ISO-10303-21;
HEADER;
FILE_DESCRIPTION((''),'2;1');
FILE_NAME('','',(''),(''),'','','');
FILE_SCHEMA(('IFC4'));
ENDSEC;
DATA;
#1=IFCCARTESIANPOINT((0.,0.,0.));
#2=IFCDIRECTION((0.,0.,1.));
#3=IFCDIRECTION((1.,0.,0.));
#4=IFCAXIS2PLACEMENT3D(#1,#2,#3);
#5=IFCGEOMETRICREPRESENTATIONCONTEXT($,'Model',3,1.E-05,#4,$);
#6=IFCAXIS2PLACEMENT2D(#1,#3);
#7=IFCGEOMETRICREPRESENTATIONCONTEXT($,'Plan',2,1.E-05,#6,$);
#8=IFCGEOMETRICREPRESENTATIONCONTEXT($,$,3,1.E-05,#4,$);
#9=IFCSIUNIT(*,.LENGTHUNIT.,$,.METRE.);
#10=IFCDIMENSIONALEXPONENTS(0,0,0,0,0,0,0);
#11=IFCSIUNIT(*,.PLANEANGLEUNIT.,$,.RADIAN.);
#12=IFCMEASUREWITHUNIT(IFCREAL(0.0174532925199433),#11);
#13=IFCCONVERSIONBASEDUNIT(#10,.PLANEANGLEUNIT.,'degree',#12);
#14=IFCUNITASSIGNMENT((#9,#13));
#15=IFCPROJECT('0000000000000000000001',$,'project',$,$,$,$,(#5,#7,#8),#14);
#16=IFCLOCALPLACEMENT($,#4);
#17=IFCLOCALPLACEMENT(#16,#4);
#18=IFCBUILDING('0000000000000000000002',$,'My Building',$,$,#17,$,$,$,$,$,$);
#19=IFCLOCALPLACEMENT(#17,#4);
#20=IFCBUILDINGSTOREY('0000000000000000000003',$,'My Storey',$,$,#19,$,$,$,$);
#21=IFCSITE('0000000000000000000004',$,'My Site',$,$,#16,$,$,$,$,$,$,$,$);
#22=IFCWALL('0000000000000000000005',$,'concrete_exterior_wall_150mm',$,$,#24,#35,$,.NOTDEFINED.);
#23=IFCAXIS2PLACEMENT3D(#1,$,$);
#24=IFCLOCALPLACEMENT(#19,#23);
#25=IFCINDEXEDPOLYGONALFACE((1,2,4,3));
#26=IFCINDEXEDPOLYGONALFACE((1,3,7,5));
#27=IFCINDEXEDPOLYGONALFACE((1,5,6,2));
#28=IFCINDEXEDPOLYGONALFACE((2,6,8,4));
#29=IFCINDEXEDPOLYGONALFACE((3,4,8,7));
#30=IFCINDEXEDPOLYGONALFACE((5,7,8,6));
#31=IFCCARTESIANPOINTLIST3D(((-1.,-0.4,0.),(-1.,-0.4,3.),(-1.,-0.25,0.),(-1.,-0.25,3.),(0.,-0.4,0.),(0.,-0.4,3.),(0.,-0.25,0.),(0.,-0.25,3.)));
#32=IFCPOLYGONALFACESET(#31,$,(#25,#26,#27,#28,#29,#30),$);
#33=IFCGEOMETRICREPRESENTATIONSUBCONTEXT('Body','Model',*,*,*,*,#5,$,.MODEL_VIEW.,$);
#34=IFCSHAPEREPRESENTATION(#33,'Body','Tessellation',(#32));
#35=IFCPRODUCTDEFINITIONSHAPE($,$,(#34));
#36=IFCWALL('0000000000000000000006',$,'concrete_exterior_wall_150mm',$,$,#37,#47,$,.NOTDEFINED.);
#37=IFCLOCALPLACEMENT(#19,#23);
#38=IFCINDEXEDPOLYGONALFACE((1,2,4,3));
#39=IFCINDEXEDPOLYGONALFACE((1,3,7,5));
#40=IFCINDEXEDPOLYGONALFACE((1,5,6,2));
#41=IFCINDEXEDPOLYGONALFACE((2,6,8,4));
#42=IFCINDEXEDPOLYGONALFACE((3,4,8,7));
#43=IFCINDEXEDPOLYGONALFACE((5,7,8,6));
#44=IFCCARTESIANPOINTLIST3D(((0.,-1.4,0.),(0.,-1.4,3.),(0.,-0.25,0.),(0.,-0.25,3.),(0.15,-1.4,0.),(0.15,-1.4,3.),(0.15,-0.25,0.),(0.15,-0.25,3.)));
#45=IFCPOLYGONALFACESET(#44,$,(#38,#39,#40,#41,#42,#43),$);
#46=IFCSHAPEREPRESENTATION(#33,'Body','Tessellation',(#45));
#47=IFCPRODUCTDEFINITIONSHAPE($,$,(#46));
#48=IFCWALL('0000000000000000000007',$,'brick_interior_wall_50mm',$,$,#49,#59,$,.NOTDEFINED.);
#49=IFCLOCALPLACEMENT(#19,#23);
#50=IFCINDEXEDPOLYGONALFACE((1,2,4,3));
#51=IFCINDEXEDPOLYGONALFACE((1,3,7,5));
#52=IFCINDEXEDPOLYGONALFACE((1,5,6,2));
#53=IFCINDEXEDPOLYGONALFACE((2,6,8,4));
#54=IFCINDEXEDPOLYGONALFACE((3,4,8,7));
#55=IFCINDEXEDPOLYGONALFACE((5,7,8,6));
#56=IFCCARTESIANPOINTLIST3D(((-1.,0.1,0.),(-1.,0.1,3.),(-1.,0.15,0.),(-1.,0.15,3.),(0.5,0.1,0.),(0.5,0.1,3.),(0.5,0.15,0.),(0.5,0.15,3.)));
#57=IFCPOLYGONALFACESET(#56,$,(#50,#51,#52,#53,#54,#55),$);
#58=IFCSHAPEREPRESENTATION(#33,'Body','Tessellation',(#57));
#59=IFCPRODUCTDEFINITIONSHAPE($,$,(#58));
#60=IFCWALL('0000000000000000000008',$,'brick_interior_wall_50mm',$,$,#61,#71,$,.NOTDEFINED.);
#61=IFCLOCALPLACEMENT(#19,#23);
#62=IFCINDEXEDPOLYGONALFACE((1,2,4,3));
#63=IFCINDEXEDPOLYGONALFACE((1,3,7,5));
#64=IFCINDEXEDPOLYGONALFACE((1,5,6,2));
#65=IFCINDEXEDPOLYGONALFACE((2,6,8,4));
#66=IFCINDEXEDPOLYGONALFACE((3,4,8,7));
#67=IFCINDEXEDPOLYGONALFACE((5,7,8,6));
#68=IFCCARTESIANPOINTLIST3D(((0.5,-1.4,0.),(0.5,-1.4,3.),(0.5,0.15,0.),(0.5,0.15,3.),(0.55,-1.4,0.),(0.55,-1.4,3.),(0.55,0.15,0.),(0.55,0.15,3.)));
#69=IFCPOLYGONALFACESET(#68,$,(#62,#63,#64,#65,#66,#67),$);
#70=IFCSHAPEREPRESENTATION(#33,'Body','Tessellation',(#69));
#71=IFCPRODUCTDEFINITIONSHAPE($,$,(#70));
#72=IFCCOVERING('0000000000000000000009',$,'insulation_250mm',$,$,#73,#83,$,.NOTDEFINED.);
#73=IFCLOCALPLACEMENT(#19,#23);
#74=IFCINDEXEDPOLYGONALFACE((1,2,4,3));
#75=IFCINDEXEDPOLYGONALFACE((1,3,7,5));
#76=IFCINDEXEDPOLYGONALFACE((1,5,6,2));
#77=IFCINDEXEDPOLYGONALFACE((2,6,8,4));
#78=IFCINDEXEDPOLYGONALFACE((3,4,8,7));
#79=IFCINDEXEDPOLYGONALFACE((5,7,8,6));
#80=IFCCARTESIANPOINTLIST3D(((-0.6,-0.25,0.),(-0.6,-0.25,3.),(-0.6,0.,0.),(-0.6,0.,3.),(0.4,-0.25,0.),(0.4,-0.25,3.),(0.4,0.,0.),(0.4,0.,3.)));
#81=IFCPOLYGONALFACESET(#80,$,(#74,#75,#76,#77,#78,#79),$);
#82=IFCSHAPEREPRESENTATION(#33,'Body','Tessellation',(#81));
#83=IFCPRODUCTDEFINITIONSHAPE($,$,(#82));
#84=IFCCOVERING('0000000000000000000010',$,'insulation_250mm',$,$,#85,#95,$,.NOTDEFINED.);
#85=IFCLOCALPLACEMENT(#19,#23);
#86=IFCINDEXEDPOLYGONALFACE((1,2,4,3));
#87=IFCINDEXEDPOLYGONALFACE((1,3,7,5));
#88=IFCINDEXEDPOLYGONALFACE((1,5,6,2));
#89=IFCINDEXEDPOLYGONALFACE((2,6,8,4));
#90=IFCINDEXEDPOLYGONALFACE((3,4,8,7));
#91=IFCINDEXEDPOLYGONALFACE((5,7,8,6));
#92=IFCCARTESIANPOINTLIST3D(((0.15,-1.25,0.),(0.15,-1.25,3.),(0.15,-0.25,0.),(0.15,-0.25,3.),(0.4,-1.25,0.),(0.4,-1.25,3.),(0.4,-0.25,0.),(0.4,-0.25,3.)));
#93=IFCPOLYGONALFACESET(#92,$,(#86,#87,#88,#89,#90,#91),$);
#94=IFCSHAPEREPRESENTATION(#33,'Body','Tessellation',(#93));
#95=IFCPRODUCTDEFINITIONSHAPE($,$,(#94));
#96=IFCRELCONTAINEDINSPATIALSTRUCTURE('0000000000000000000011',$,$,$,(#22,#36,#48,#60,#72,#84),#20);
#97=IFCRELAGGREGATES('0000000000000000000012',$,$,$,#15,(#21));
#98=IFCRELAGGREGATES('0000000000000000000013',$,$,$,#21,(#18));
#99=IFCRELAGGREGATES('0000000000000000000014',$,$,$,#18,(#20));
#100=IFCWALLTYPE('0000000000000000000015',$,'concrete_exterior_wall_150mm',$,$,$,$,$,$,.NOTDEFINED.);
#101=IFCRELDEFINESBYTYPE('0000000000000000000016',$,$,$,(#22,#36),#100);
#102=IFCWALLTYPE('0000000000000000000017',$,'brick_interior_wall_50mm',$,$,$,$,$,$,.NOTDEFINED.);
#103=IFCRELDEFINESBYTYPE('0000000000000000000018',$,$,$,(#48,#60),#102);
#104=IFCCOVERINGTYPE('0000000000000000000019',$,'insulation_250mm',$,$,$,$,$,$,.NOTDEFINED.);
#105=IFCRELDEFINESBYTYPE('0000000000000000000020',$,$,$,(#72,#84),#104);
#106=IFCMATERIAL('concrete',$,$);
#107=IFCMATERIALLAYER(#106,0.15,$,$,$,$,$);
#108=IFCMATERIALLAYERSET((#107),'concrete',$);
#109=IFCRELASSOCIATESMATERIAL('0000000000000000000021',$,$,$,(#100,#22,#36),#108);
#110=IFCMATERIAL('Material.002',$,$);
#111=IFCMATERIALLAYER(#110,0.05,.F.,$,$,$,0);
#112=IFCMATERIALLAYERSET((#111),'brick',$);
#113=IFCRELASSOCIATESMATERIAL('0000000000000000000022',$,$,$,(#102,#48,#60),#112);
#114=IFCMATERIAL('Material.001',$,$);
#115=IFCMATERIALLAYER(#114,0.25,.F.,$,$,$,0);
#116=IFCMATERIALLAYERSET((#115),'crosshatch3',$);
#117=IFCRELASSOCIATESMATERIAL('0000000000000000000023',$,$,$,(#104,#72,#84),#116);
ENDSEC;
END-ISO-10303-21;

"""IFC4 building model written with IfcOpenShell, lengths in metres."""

from ifc_helpers import new_model, entity, si_unit, converted_unit, frame, frame_2d, origin_with_axes, place, context, subcontext, project, spatial, indexed_curve, outline, extrude, material, layer, layer_set, layer_usage, type_object, element, save


model = new_model("IFC4")

# Units and contexts
model_context = context("Model", 3, precision=1e-05, world=origin_with_axes())
plan_context = context("Plan", 2, precision=1e-05, world=frame_2d((0.0, 0.0, 0.0), x_axis=(1.0, 0.0, 0.0)))
context_of_model = context(None, 3, precision=1e-05, world=origin_with_axes())
body_context = subcontext(model_context, "Body", "Model", "MODEL_VIEW")
ifc_project = project(units=[si_unit("LENGTHUNIT", "METRE"), converted_unit("PLANEANGLEUNIT", "degree", entity("IfcReal", 0.0174532925199433), si_unit("PLANEANGLEUNIT", "RADIAN"), dimensions=[0, 0, 0, 0, 0, 0, 0])], contexts=[model_context, plan_context, context_of_model])

# Site, building, storey
site_placement = place(None, origin_with_axes())
site = spatial("IfcSite", under=ifc_project, at=site_placement, Name="My Site")
building_placement = place(site_placement, origin_with_axes())
building = spatial("IfcBuilding", under=site, at=building_placement, Name="My Building")
storey_placement = place(building_placement, origin_with_axes())
storey = spatial("IfcBuildingStorey", under=building, at=storey_placement, Name="My Storey")

# Walls
ifc_material_1 = material(Name="concrete")
ifc_layer_1 = layer(ifc_material_1, 0.15)
ifc_layer_set_1 = layer_set([ifc_layer_1], Name="concrete")
ifc_layer_usage_1 = layer_usage(ifc_layer_set_1, "AXIS2", "POSITIVE", 0.0)
wall_type_1 = type_object("IfcWallType", Name="concrete_exterior_wall_150mm", PredefinedType="NOTDEFINED", material=ifc_layer_set_1)
wall_1_placement = place(storey_placement, frame((-1.0, -0.4, 0.0), z_axis=(0.0, 0.0, 1.0), x_axis=(1.0, 0.0, 0.0)))
element("IfcWall", 1, at=wall_1_placement, inside=storey, type_object=wall_type_1, material=ifc_layer_usage_1, Name="concrete_exterior_wall_150mm", PredefinedType="NOTDEFINED", context=body_context, shape_type="SweptSolid", body=[
    extrude(outline(indexed_curve([(0.0, 0.0), (0.0, 0.15), (1.0, 0.15), (1.0, 0.0), (0.0, 0.0)], self_intersect=False)), origin_with_axes(), (0.0, 0.0, 1.0), 3.0),
])
ifc_layer_usage_2 = layer_usage(ifc_layer_set_1, "AXIS2", "POSITIVE", 0.0)
wall_2_placement = place(storey_placement, frame((0.0, -0.25, 0.0), z_axis=(0.0, 0.0, 1.0), x_axis=(0.0, -1.0, 0.0)))
element("IfcWall", 2, at=wall_2_placement, inside=storey, type_object=wall_type_1, material=ifc_layer_usage_2, Name="concrete_exterior_wall_150mm", PredefinedType="NOTDEFINED", context=body_context, shape_type="SweptSolid", body=[
    extrude(outline(indexed_curve([(0.0, 0.0), (0.0, 0.15), (1.15, 0.15), (1.15, 0.0), (0.0, 0.0)], self_intersect=False)), origin_with_axes(), (0.0, 0.0, 1.0), 3.0),
])
ifc_material_2 = material(Name="Material.002")
ifc_layer_2 = layer(ifc_material_2, 0.05, ventilated=False, Priority=0)
ifc_layer_set_2 = layer_set([ifc_layer_2], Name="brick")
ifc_layer_usage_3 = layer_usage(ifc_layer_set_2, "AXIS2", "POSITIVE", 0.0)
wall_type_2 = type_object("IfcWallType", Name="brick_interior_wall_50mm", PredefinedType="NOTDEFINED", material=ifc_layer_set_2)
wall_3_placement = place(storey_placement, frame((-1.0, 0.1, 0.0), z_axis=(0.0, 0.0, 1.0), x_axis=(1.0, 0.0, 0.0)))
element("IfcWall", 3, at=wall_3_placement, inside=storey, type_object=wall_type_2, material=ifc_layer_usage_3, Name="brick_interior_wall_50mm", PredefinedType="NOTDEFINED", context=body_context, shape_type="SweptSolid", body=[
    extrude(outline(indexed_curve([(0.0, 0.0), (0.0, 0.05), (1.5, 0.05), (1.5, 0.0), (0.0, 0.0)], self_intersect=False)), origin_with_axes(), (0.0, 0.0, 1.0), 3.0),
])
ifc_layer_usage_4 = layer_usage(ifc_layer_set_2, "AXIS2", "POSITIVE", 0.0)
wall_4_placement = place(storey_placement, frame((0.5, 0.15, 0.0), z_axis=(0.0, 0.0, 1.0), x_axis=(0.0, -1.0, 0.0)))
element("IfcWall", 4, at=wall_4_placement, inside=storey, type_object=wall_type_2, material=ifc_layer_usage_4, Name="brick_interior_wall_50mm", PredefinedType="NOTDEFINED", context=body_context, shape_type="SweptSolid", body=[
    extrude(outline(indexed_curve([(0.0, 0.0), (0.0, 0.05), (1.55, 0.05), (1.55, 0.0), (0.0, 0.0)], self_intersect=False)), origin_with_axes(), (0.0, 0.0, 1.0), 3.0),
])

# Coverings
ifc_material_3 = material(Name="Material.001")
ifc_layer_3 = layer(ifc_material_3, 0.25, ventilated=False, Priority=0)
ifc_layer_set_3 = layer_set([ifc_layer_3], Name="crosshatch3")
ifc_layer_usage_5 = layer_usage(ifc_layer_set_3, "AXIS2", "POSITIVE", 0.0)
covering_type = type_object("IfcCoveringType", Name="insulation_250mm", PredefinedType="NOTDEFINED", material=ifc_layer_set_3)
covering_1_placement = place(storey_placement, frame((0.4, 0.0, 0.0), z_axis=(0.0, 0.0, 1.0), x_axis=(-1.0, 0.0, 0.0)))
element("IfcCovering", 5, at=covering_1_placement, inside=storey, type_object=covering_type, material=ifc_layer_usage_5, Name="insulation_250mm", PredefinedType="NOTDEFINED", context=body_context, shape_type="SweptSolid", body=[
    extrude(outline(indexed_curve([(0.0, 0.0), (0.0, 0.25), (1.0, 0.25), (1.0, 0.0), (0.0, 0.0)], self_intersect=False)), origin_with_axes(), (0.0, 0.0, 1.0), 3.0),
])
ifc_layer_usage_6 = layer_usage(ifc_layer_set_3, "AXIS2", "POSITIVE", 0.0)
covering_2_placement = place(storey_placement, frame((0.15, -0.25, 0.0), z_axis=(0.0, 0.0, 1.0), x_axis=(0.0, -1.0, 0.0)))
element("IfcCovering", 6, at=covering_2_placement, inside=storey, type_object=covering_type, material=ifc_layer_usage_6, Name="insulation_250mm", PredefinedType="NOTDEFINED", context=body_context, shape_type="SweptSolid", body=[
    extrude(outline(indexed_curve([(0.0, 0.0), (0.0, 0.25), (1.0, 0.25), (1.0, 0.0), (0.0, 0.0)], self_intersect=False)), origin_with_axes(), (0.0, 0.0, 1.0), 3.0),
])

save(model, "model.ifc")
